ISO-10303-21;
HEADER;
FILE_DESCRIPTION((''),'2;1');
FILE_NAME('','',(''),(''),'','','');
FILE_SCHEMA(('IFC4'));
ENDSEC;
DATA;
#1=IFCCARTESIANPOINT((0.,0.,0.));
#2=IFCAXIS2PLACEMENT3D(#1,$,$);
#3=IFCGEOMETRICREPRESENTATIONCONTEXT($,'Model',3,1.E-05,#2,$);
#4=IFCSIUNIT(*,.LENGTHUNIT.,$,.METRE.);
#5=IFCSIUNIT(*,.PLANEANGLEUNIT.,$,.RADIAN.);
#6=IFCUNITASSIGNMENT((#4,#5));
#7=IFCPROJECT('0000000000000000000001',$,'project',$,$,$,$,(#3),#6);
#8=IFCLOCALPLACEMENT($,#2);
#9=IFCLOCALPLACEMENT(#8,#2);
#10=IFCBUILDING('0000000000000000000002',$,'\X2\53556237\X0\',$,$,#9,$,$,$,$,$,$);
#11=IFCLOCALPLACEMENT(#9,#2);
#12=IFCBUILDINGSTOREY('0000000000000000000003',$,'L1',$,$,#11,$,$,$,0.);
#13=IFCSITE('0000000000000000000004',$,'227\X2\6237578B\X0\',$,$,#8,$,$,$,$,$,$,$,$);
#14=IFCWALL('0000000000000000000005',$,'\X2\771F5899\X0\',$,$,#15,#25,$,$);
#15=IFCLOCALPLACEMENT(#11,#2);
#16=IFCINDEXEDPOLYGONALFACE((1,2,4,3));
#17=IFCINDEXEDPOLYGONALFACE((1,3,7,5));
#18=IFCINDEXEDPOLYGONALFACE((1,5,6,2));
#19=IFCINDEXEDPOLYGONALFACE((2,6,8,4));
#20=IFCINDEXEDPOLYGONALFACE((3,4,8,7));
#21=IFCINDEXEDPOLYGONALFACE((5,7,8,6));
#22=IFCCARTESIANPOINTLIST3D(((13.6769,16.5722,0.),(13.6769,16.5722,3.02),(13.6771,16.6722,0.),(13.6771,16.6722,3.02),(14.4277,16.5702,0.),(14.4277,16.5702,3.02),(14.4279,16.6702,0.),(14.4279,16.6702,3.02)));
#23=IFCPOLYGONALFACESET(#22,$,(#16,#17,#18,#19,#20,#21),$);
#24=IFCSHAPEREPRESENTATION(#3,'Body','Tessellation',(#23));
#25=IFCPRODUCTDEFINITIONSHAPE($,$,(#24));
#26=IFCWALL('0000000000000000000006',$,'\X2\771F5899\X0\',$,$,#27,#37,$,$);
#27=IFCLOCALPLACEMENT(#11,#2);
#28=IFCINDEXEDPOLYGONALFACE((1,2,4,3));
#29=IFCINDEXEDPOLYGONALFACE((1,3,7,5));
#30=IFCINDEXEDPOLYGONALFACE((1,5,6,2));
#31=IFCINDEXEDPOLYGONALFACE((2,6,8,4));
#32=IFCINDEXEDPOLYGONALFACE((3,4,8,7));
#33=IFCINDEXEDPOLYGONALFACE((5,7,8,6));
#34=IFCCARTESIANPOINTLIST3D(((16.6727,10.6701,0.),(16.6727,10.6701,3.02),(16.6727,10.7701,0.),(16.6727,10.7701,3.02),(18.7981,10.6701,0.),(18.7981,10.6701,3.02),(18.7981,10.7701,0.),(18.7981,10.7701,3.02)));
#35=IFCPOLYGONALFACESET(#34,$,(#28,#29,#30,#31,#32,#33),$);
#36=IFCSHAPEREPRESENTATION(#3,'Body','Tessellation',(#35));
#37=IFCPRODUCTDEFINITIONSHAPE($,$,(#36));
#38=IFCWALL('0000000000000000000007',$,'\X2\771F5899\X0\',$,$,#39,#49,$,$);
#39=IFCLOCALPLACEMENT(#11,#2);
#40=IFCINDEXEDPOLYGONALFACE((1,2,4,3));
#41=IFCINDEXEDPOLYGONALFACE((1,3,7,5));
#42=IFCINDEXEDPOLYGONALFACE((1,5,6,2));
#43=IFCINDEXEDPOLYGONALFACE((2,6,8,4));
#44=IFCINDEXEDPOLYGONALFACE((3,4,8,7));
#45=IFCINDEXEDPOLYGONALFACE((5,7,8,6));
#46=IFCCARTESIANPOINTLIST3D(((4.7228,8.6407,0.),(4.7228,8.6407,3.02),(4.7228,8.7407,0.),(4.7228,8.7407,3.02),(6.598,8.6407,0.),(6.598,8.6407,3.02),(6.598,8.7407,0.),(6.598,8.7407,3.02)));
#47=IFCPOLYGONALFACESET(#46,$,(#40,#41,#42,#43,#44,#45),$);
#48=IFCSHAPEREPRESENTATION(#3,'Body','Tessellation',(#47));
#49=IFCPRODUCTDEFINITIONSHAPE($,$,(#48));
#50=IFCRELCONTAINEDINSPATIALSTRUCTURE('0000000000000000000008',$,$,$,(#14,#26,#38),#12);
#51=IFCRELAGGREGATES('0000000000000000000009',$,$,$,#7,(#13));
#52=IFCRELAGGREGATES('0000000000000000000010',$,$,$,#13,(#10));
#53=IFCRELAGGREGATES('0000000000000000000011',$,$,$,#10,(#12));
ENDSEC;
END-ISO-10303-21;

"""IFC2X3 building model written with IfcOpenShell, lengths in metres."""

from ifc_helpers import new_model, si_unit, origin, place, context, project, spatial, polyline, outline, extrude, element, save


model = new_model("IFC2X3")

# Units and contexts
model_context = context("Model", 3, precision=1e-05, world=origin())
ifc_project = project(units=[si_unit("LENGTHUNIT", "METRE"), si_unit("PLANEANGLEUNIT", "RADIAN")], contexts=[model_context])

# Site, building, storey
site_placement = place(None, origin())
site = spatial("IfcSite", under=ifc_project, at=site_placement, Name="227户型")
building_placement = place(site_placement, origin())
building = spatial("IfcBuilding", under=site, at=building_placement, Name="单户")
storey_placement = place(building_placement, origin())
storey = spatial("IfcBuildingStorey", under=building, at=storey_placement, Name="L1", Elevation=0.0)

# Walls
wall_1_placement = place(storey_placement, origin())
element("IfcWall", 1, at=wall_1_placement, inside=storey, Name="真墙", context=model_context, shape_type="SweptSolid", body=[
    extrude(outline(polyline([(14.4277, 16.5702), (13.6769, 16.5722), (13.6771, 16.6722), (14.4279, 16.6702), (14.4277, 16.5702)])), origin(), (0.0, 0.0, 1.0), 3.02),
])
wall_2_placement = place(storey_placement, origin())
element("IfcWall", 2, at=wall_2_placement, inside=storey, Name="真墙", context=model_context, shape_type="SweptSolid", body=[
    extrude(outline(polyline([(16.6727, 10.7701), (18.7981, 10.7701), (18.7981, 10.6701), (16.6727, 10.6701), (16.6727, 10.7701)])), origin(), (0.0, 0.0, 1.0), 3.02),
])
wall_3_placement = place(storey_placement, origin())
element("IfcWall", 3, at=wall_3_placement, inside=storey, Name="真墙", context=model_context, shape_type="SweptSolid", body=[
    extrude(outline(polyline([(4.7228, 8.7407), (6.598, 8.7407), (6.598, 8.6407), (4.7228, 8.6407), (4.7228, 8.7407)])), origin(), (0.0, 0.0, 1.0), 3.02),
])

save(model, "model.ifc")
